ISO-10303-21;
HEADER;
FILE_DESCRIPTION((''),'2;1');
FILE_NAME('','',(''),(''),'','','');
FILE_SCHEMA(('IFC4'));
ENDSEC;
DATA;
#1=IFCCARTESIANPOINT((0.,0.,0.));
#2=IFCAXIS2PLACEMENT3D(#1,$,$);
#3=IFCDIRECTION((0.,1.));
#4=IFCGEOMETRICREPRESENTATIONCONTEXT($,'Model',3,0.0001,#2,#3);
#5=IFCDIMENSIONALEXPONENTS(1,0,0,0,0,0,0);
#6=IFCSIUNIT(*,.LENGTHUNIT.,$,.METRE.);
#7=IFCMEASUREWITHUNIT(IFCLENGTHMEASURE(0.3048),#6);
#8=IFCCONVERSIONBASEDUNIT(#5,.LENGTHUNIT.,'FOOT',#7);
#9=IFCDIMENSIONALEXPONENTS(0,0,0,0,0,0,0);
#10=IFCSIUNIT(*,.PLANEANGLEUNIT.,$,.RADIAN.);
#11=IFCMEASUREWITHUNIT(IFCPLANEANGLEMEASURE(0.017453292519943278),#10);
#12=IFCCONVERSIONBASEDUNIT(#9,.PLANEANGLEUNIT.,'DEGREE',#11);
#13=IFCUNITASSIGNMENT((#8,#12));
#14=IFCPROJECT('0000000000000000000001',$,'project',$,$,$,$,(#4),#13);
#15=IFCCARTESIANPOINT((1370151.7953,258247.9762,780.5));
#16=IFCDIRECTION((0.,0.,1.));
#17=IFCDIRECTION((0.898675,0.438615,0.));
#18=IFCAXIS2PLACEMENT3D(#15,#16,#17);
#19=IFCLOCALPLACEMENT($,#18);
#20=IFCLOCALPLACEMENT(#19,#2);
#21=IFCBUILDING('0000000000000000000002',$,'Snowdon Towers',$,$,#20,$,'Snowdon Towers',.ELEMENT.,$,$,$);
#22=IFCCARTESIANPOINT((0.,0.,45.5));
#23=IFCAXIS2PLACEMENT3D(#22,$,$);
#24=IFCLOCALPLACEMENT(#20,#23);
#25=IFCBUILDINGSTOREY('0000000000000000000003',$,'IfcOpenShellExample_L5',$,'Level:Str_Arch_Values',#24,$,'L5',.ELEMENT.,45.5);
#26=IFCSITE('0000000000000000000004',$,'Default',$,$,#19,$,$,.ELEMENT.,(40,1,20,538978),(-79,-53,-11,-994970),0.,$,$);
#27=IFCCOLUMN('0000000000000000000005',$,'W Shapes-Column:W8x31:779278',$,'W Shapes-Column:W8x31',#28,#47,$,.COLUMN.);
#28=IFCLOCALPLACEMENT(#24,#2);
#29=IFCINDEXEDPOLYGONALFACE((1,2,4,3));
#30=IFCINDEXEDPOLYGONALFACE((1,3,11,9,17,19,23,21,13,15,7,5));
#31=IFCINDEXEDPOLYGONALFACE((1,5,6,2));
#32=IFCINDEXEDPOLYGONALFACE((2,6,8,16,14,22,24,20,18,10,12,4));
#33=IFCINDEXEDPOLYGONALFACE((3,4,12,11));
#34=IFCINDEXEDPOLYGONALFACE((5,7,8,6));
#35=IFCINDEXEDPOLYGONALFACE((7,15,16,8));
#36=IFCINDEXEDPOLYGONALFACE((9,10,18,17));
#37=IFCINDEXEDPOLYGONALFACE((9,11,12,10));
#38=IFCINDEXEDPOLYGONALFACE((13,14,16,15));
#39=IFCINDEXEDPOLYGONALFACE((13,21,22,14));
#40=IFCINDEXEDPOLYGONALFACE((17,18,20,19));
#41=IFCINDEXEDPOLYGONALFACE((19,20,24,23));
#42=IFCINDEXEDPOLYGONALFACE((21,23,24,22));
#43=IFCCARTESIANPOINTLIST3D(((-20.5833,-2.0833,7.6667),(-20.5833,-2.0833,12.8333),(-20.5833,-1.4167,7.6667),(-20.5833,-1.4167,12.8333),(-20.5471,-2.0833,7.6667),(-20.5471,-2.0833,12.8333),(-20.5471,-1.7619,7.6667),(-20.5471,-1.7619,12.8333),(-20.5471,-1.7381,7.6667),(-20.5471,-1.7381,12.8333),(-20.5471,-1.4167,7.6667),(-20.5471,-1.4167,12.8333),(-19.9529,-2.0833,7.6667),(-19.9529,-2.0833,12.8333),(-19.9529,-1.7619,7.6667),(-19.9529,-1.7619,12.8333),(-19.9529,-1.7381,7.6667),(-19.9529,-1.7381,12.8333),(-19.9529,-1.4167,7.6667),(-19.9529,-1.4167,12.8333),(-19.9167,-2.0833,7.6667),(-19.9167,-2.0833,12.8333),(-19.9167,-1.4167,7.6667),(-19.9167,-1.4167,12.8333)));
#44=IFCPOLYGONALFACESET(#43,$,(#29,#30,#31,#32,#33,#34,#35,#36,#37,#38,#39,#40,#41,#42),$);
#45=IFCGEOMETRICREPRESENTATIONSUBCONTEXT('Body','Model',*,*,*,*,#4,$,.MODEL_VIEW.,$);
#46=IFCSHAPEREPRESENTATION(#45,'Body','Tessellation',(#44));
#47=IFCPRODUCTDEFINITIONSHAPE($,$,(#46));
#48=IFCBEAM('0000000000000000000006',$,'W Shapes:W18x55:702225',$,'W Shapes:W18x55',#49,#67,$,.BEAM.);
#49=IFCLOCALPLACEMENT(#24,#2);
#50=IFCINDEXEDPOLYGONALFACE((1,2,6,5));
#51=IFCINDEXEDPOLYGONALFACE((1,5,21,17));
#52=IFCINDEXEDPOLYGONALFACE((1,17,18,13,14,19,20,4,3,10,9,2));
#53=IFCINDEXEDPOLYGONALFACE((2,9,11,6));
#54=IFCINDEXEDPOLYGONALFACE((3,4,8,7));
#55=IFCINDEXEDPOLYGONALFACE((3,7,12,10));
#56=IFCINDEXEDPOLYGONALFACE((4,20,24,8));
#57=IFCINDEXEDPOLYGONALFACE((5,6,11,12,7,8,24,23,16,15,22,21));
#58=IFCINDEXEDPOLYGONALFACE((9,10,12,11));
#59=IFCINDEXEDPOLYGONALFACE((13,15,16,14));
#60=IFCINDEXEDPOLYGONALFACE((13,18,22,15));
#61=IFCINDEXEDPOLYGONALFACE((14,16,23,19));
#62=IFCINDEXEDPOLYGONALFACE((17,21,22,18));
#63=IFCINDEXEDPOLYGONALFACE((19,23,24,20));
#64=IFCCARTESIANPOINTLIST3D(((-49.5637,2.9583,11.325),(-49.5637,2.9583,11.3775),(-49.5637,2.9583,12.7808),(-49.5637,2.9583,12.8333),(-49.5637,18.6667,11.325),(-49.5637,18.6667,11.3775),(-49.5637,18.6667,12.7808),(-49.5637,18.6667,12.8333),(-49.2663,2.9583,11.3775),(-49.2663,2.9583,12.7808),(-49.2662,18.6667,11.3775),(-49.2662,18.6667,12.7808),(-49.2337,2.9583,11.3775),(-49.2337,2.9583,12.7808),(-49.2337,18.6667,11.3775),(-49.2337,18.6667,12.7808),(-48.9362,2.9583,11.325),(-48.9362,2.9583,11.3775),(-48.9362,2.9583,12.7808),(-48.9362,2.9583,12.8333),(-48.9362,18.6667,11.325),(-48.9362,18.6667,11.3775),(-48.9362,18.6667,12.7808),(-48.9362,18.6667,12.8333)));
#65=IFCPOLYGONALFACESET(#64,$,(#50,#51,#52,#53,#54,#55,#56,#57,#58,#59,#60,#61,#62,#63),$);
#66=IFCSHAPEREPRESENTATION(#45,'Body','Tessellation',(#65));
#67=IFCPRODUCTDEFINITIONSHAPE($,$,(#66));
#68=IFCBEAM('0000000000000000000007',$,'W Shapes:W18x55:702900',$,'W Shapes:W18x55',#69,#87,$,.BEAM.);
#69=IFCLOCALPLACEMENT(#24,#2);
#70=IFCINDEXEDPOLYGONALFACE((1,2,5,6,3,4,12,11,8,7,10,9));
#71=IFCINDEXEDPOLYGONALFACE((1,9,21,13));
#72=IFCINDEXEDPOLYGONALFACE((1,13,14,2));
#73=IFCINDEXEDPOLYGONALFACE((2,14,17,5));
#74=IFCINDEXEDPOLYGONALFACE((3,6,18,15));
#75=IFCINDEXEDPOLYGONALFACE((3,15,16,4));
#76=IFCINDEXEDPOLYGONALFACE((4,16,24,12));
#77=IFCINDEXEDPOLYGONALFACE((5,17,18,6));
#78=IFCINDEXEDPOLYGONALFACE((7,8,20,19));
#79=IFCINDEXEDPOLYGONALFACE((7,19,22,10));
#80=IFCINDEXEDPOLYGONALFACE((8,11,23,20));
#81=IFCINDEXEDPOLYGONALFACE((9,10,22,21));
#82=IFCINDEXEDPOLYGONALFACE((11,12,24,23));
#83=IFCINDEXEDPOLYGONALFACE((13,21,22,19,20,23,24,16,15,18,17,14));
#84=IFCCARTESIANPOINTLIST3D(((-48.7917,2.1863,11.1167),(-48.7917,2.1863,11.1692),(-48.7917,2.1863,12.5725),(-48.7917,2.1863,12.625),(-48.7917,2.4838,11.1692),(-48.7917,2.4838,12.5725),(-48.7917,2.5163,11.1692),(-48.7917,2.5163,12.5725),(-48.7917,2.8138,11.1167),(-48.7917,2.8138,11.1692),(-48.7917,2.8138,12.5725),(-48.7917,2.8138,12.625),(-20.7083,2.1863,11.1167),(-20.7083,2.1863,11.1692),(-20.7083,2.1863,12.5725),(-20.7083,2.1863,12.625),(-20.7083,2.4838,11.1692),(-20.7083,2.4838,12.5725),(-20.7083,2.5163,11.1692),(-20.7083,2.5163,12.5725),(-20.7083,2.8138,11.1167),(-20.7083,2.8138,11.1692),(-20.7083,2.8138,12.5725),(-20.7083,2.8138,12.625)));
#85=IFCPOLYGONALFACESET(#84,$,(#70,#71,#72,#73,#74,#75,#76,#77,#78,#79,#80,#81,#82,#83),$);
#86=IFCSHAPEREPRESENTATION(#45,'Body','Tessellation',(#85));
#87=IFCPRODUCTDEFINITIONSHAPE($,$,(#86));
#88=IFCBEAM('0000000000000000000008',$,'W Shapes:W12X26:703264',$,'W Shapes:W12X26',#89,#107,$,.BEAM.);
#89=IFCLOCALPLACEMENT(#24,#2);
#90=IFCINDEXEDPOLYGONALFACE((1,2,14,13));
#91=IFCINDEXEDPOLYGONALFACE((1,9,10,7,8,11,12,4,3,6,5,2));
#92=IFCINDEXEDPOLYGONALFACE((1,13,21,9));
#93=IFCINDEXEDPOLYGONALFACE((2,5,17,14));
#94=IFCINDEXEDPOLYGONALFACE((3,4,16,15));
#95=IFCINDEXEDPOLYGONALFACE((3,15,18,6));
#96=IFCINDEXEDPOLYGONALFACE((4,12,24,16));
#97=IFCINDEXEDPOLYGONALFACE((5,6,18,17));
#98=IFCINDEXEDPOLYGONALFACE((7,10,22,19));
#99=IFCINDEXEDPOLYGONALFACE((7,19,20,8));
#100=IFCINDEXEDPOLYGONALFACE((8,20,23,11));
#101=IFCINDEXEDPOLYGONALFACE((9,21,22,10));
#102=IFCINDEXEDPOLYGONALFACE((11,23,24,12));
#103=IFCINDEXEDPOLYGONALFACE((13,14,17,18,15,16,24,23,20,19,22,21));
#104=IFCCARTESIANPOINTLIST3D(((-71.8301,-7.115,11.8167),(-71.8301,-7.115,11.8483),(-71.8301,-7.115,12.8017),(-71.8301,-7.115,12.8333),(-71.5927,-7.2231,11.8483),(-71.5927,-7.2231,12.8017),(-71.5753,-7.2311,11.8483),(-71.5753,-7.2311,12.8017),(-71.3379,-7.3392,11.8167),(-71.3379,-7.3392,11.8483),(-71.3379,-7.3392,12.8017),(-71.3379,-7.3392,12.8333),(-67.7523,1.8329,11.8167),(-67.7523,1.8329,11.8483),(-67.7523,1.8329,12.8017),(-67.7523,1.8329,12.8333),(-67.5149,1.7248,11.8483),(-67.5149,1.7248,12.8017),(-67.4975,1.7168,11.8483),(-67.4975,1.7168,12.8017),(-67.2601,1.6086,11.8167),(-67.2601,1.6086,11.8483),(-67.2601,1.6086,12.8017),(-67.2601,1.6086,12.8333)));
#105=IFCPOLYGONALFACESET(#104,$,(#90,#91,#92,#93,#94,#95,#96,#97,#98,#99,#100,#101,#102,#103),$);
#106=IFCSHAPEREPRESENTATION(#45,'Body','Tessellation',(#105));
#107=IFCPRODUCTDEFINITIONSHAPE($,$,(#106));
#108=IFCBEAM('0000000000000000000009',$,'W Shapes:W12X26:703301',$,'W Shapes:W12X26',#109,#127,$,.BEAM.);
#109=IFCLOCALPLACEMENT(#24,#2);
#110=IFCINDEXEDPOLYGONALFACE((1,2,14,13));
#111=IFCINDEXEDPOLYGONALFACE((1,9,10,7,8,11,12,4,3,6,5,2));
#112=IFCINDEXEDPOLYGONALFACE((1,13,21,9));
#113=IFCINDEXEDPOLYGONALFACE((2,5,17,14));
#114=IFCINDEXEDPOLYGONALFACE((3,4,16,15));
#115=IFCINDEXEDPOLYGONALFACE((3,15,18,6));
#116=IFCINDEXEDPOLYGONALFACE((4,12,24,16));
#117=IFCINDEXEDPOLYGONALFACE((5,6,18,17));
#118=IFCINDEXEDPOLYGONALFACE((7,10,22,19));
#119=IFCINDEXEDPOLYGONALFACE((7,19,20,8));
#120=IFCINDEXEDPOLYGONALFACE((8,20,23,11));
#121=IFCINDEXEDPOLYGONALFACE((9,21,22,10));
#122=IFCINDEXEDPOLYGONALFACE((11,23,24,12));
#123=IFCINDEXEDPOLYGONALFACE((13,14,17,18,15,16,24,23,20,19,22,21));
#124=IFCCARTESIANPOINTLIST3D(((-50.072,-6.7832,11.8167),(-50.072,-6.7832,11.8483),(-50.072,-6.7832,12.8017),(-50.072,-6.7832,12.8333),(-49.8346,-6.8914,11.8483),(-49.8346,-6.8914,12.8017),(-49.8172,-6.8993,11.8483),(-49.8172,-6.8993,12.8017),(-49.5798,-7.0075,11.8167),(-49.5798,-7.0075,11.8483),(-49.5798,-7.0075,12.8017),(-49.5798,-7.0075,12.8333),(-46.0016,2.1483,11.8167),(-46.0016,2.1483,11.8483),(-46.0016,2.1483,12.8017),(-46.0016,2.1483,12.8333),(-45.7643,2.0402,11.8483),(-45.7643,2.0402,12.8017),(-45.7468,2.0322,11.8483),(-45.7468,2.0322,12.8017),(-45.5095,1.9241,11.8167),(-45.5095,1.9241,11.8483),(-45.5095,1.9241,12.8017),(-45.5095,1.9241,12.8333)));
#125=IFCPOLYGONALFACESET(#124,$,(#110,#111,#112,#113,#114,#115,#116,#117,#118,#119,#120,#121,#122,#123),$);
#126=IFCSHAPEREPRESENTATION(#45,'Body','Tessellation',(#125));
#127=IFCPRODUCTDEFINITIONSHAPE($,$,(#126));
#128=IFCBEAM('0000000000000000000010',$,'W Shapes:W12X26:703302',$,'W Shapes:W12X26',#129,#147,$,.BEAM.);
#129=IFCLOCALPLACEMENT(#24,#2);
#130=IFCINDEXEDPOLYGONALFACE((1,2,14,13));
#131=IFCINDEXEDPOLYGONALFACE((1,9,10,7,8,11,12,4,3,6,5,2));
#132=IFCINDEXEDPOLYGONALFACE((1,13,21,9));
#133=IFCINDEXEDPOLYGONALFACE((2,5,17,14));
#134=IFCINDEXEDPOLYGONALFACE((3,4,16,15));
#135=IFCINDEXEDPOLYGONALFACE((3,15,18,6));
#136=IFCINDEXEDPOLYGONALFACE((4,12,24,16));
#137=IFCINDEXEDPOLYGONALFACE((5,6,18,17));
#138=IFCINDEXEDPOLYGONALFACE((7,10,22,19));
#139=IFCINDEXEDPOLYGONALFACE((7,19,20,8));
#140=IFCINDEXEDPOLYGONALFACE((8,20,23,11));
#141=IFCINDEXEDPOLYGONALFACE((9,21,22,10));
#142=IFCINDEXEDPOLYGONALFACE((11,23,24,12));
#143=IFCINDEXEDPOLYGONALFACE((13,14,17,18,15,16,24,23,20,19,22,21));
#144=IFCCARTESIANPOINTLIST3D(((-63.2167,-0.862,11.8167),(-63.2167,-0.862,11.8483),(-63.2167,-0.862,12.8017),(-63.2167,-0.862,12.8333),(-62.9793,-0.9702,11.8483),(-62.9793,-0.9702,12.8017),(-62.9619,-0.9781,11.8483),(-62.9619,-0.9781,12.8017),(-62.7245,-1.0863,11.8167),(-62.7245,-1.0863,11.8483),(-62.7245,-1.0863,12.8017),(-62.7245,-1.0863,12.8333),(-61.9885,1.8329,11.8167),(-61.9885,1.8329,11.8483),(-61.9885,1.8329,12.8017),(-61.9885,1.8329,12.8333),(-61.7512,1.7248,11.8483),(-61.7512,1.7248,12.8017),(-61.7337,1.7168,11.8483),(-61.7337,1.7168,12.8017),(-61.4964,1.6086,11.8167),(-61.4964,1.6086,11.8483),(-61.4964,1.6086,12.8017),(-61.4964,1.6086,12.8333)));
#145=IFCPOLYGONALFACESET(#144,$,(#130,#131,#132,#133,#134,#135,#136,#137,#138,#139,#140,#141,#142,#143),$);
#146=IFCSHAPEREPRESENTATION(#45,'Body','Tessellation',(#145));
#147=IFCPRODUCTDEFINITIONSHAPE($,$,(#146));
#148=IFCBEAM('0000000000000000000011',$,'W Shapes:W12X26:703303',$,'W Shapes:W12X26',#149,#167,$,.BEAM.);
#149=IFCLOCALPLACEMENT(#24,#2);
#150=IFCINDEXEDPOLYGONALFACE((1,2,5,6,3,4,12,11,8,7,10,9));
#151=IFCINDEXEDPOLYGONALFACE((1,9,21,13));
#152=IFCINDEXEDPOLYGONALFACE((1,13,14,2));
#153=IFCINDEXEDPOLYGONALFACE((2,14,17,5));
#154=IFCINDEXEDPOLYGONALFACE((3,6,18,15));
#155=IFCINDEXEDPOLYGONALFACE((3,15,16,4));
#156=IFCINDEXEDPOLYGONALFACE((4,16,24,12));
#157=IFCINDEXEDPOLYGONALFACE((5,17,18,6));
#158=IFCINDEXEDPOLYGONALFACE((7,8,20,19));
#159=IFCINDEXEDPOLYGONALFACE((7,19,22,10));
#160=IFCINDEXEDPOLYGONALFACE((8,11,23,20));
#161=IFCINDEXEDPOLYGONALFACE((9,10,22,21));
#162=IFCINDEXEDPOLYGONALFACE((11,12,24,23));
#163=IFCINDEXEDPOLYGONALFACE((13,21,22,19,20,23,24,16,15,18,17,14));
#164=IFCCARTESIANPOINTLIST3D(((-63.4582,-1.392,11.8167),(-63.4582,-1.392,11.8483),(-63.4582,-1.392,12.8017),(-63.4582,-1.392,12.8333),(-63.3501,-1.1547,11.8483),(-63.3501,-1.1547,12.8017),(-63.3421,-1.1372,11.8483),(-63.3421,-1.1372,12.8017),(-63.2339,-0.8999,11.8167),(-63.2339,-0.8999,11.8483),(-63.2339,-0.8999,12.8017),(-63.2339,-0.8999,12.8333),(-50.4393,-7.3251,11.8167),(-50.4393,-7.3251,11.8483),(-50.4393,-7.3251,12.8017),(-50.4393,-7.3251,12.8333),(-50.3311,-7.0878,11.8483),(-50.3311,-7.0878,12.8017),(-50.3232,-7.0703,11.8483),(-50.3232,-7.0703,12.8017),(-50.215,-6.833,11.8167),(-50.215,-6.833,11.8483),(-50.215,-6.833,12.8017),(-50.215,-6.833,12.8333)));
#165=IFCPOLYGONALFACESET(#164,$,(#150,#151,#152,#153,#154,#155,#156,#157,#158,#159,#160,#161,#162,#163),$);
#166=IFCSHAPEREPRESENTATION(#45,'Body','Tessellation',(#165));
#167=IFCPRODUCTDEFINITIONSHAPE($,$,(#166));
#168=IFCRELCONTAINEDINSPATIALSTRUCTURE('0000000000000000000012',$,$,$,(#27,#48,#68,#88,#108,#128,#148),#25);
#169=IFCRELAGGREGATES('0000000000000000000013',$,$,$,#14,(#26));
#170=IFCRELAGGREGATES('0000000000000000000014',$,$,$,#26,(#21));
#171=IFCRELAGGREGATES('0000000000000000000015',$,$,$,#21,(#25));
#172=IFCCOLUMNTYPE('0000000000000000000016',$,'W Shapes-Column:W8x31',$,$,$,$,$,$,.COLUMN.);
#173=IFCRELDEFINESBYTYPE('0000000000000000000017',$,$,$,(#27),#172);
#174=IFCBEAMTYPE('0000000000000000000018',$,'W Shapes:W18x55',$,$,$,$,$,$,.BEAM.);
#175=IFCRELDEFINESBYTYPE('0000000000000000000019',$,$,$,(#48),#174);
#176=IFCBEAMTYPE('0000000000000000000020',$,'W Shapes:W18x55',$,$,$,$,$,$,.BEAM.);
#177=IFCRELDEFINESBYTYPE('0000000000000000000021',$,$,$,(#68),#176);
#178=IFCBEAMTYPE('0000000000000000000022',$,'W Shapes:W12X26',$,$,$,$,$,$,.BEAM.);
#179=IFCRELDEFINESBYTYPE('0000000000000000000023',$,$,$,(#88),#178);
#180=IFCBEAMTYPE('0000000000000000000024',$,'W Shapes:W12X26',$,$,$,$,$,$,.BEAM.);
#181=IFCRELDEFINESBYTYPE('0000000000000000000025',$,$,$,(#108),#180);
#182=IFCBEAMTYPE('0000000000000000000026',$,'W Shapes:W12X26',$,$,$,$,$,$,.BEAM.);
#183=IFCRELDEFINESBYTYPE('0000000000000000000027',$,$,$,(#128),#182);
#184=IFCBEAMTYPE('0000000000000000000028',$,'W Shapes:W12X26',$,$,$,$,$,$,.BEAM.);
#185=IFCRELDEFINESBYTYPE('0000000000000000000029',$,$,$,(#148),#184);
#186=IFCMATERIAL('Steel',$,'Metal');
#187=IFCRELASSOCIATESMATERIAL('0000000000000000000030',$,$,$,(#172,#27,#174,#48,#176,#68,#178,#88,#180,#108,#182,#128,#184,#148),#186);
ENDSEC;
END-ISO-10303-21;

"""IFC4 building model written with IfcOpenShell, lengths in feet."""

from ifc_helpers import new_model, entity, si_unit, converted_unit, direction, frame, origin, place, context, subcontext, project, spatial, indexed_curve, outline, extrude, source, transform, mapped, material, type_object, type_shapes, element, save


model = new_model("IFC4")

# Units and contexts
model_context = context("Model", 3, precision=0.0001, world=origin(), true_north=direction((0.0, 1.0)))
body_context = subcontext(model_context, "Body", "Model", "MODEL_VIEW")
ifc_project = project(units=[converted_unit("LENGTHUNIT", "FOOT", entity("IfcLengthMeasure", 0.3048), si_unit("LENGTHUNIT", "METRE"), dimensions=[1, 0, 0, 0, 0, 0, 0]), converted_unit("PLANEANGLEUNIT", "DEGREE", entity("IfcPlaneAngleMeasure", 0.017453292519943278), si_unit("PLANEANGLEUNIT", "RADIAN"), dimensions=[0, 0, 0, 0, 0, 0, 0])], contexts=[model_context])

# Site, building, storey
site_placement = place(None, frame((1370151.7953, 258247.9762, 780.5), z_axis=(0.0, 0.0, 1.0), x_axis=(0.898675, 0.438615, 0.0)))
site = spatial("IfcSite", under=ifc_project, at=site_placement, Name="Default", CompositionType="ELEMENT", RefLatitude=(40, 1, 20, 538978), RefLongitude=(-79, -53, -11, -994970), RefElevation=0.0)
building_placement = place(site_placement, origin())
building = spatial("IfcBuilding", under=site, at=building_placement, Name="Snowdon Towers", LongName="Snowdon Towers", CompositionType="ELEMENT")
storey_placement = place(building_placement, frame((0.0, 0.0, 45.5)))
storey = spatial("IfcBuildingStorey", under=building, at=storey_placement, Name="IfcOpenShellExample_L5", ObjectType="Level:Str_Arch_Values", LongName="L5", CompositionType="ELEMENT", Elevation=45.5)

# Column
ifc_material = material(Name="Steel", Category="Metal")
column_type = type_object("IfcColumnType", Name="W Shapes-Column:W8x31", PredefinedType="COLUMN", material=ifc_material)
shared_shape_1 = source(origin(), body_context, "Body", "SweptSolid", [
    extrude(outline(indexed_curve([(-0.3333, -0.3333), (-0.2971, -0.3333), (-0.2971, -0.0119), (0.2971, -0.0119), (0.2971, -0.3333), (0.3333, -0.3333), (0.3333, 0.3333), (0.2971, 0.3333), (0.2971, 0.0119), (-0.2971, 0.0119), (-0.2971, 0.3333), (-0.3333, 0.3333), (-0.3333, -0.3333)], self_intersect=False)), frame((0.0, 0.0, 53.1667), z_axis=(0.0, 0.0, 1.0), x_axis=(0.0, 1.0, 0.0)), (0.0, 0.0, 1.0), 5.1667),
])
type_shapes(column_type, [shared_shape_1])
column_placement = place(storey_placement, frame((-20.25, -1.75, -45.5), z_axis=(0.0, 0.0, 1.0), x_axis=(0.0, 1.0, 0.0)))
element("IfcColumn", 1, at=column_placement, inside=storey, type_object=column_type, material=ifc_material, Name="W Shapes-Column:W8x31:779278", ObjectType="W Shapes-Column:W8x31", PredefinedType="COLUMN", context=body_context, shape_type="MappedRepresentation", body=[
    mapped(shared_shape_1, transform((0.0, 0.0, 0.0), scale=1.0)),
])

# Beams
beam_type_1 = type_object("IfcBeamType", Name="W Shapes:W18x55", PredefinedType="BEAM", material=ifc_material)
shared_shape_2 = source(origin(), body_context, "Body", "SweptSolid", [
    extrude(outline(indexed_curve([(-0.3138, -0.7017), (-0.3138, -0.7542), (0.3138, -0.7542), (0.3138, -0.7017), (0.0162, -0.7017), (0.0162, 0.7017), (0.3138, 0.7017), (0.3138, 0.7542), (-0.3137, 0.7542), (-0.3137, 0.7017), (-0.0163, 0.7017), (-0.0163, -0.7017), (-0.3138, -0.7017)], self_intersect=False)), frame((-7.8125, 0.0, 0.0), z_axis=(-1.0, 0.0, 0.0), x_axis=(0.0, -1.0, 0.0)), (0.0, 0.0, -1.0), 15.7083),
])
type_shapes(beam_type_1, [shared_shape_2])
beam_1_placement = place(storey_placement, frame((-49.25, 10.8542, 12.0792), z_axis=(0.0, 0.0, 1.0), x_axis=(0.0, -1.0, 0.0)))
element("IfcBeam", 2, at=beam_1_placement, inside=storey, type_object=beam_type_1, material=ifc_material, Name="W Shapes:W18x55:702225", ObjectType="W Shapes:W18x55", PredefinedType="BEAM", context=body_context, shape_type="MappedRepresentation", body=[
    mapped(shared_shape_2, transform((0.0, 0.0, 0.0), scale=1.0)),
])
beam_type_2 = type_object("IfcBeamType", Name="W Shapes:W18x55", PredefinedType="BEAM", material=ifc_material)
shared_shape_3 = source(origin(), body_context, "Body", "SweptSolid", [
    extrude(outline(indexed_curve([(-0.3138, -0.7017), (-0.3138, -0.7542), (0.3138, -0.7542), (0.3138, -0.7017), (0.0162, -0.7017), (0.0162, 0.7017), (0.3138, 0.7017), (0.3138, 0.7542), (-0.3137, 0.7542), (-0.3137, 0.7017), (-0.0163, 0.7017), (-0.0163, -0.7017), (-0.3138, -0.7017)], self_intersect=False)), frame((-14.0417, 0.0, 0.0), z_axis=(-1.0, 0.0, 0.0), x_axis=(0.0, -1.0, 0.0)), (0.0, 0.0, -1.0), 28.0833),
])
type_shapes(beam_type_2, [shared_shape_3])
beam_2_placement = place(storey_placement, frame((-34.75, 2.5, 11.8708)))
element("IfcBeam", 3, at=beam_2_placement, inside=storey, type_object=beam_type_2, material=ifc_material, Name="W Shapes:W18x55:702900", ObjectType="W Shapes:W18x55", PredefinedType="BEAM", context=body_context, shape_type="MappedRepresentation", body=[
    mapped(shared_shape_3, transform((0.0, 0.0, 0.0), scale=1.0)),
])
beam_type_3 = type_object("IfcBeamType", Name="W Shapes:W12X26", PredefinedType="BEAM", material=ifc_material)
shared_shape_4 = source(origin(), body_context, "Body", "SweptSolid", [
    extrude(outline(indexed_curve([(-0.2704, -0.4767), (-0.2704, -0.5083), (0.2704, -0.5083), (0.2704, -0.4767), (0.0096, -0.4767), (0.0096, 0.4767), (0.2704, 0.4767), (0.2704, 0.5083), (-0.2704, 0.5083), (-0.2704, 0.4767), (-0.0096, 0.4767), (-0.0096, -0.4767), (-0.2704, -0.4767)], self_intersect=False)), frame((-5.1887, 0.0, 0.0), z_axis=(-1.0, 0.0, 0.0), x_axis=(0.0, -1.0, 0.0)), (0.0, 0.0, -1.0), 9.8332),
])
type_shapes(beam_type_3, [shared_shape_4])
beam_3_placement = place(storey_placement, frame((-69.4323, -2.5055, 12.325), z_axis=(0.0, 0.0, 1.0), x_axis=(0.414693, 0.909961, 0.0)))
element("IfcBeam", 4, at=beam_3_placement, inside=storey, type_object=beam_type_3, material=ifc_material, Name="W Shapes:W12X26:703264", ObjectType="W Shapes:W12X26", PredefinedType="BEAM", context=body_context, shape_type="MappedRepresentation", body=[
    mapped(shared_shape_4, transform((0.0, 0.0, 0.0), scale=1.0)),
])
beam_type_4 = type_object("IfcBeamType", Name="W Shapes:W12X26", PredefinedType="BEAM", material=ifc_material)
shared_shape_5 = source(origin(), body_context, "Body", "SweptSolid", [
    extrude(outline(indexed_curve([(-0.2704, -0.4767), (-0.2704, -0.5083), (0.2704, -0.5083), (0.2704, -0.4767), (0.0096, -0.4767), (0.0096, 0.4767), (0.2704, 0.4767), (0.2704, 0.5083), (-0.2704, 0.5083), (-0.2704, 0.4767), (-0.0096, 0.4767), (-0.0096, -0.4767), (-0.2704, -0.4767)], self_intersect=False)), frame((-4.9762, 0.0, 0.0), z_axis=(-1.0, 0.0, 0.0), x_axis=(0.0, -1.0, 0.0)), (0.0, 0.0, -1.0), 9.8153),
])
type_shapes(beam_type_4, [shared_shape_5])
beam_4_placement = place(storey_placement, frame((-47.7623, -2.3673, 12.325), z_axis=(0.0, 0.0, 1.0), x_axis=(0.414693, 0.909961, 0.0)))
element("IfcBeam", 5, at=beam_4_placement, inside=storey, type_object=beam_type_4, material=ifc_material, Name="W Shapes:W12X26:703301", ObjectType="W Shapes:W12X26", PredefinedType="BEAM", context=body_context, shape_type="MappedRepresentation", body=[
    mapped(shared_shape_5, transform((0.0, 0.0, 0.0), scale=1.0)),
])
beam_type_5 = type_object("IfcBeamType", Name="W Shapes:W12X26", PredefinedType="BEAM", material=ifc_material)
shared_shape_6 = source(origin(), body_context, "Body", "SweptSolid", [
    extrude(outline(indexed_curve([(-0.2704, -0.4767), (-0.2704, -0.5083), (0.2704, -0.5083), (0.2704, -0.4767), (0.0096, -0.4767), (0.0096, 0.4767), (0.2704, 0.4767), (0.2704, 0.5083), (-0.2704, 0.5083), (-0.2704, 0.4767), (-0.0096, 0.4767), (-0.0096, -0.4767), (-0.2704, -0.4767)], self_intersect=False)), frame((-1.7529, 0.0, 0.0), z_axis=(-1.0, 0.0, 0.0), x_axis=(0.0, -1.0, 0.0)), (0.0, 0.0, -1.0), 2.9616),
])
type_shapes(beam_type_5, [shared_shape_6])
beam_5_placement = place(storey_placement, frame((-62.2437, 0.6209, 12.325), z_axis=(0.0, 0.0, 1.0), x_axis=(0.414693, 0.909961, 0.0)))
element("IfcBeam", 6, at=beam_5_placement, inside=storey, type_object=beam_type_5, material=ifc_material, Name="W Shapes:W12X26:703302", ObjectType="W Shapes:W12X26", PredefinedType="BEAM", context=body_context, shape_type="MappedRepresentation", body=[
    mapped(shared_shape_6, transform((0.0, 0.0, 0.0), scale=1.0)),
])
beam_type_6 = type_object("IfcBeamType", Name="W Shapes:W12X26", PredefinedType="BEAM", material=ifc_material)
shared_shape_7 = source(origin(), body_context, "Body", "SweptSolid", [
    extrude(outline(indexed_curve([(-0.2704, -0.4767), (-0.2704, -0.5083), (0.2704, -0.5083), (0.2704, -0.4767), (0.0096, -0.4767), (0.0096, 0.4767), (0.2704, 0.4767), (0.2704, 0.5083), (-0.2704, 0.5083), (-0.2704, 0.4767), (-0.0096, 0.4767), (-0.0096, -0.4767), (-0.2704, -0.4767)], self_intersect=False)), frame((-7.4813, 0.0, 0.0), z_axis=(-1.0, 0.0, 0.0), x_axis=(0.0, -1.0, 0.0)), (0.0, 0.0, -1.0), 14.3071),
])
type_shapes(beam_type_6, [shared_shape_7])
beam_6_placement = place(storey_placement, frame((-56.5384, -4.2484, 12.325), z_axis=(0.0, 0.0, 1.0), x_axis=(0.909961, -0.414693, 0.0)))
element("IfcBeam", 7, at=beam_6_placement, inside=storey, type_object=beam_type_6, material=ifc_material, Name="W Shapes:W12X26:703303", ObjectType="W Shapes:W12X26", PredefinedType="BEAM", context=body_context, shape_type="MappedRepresentation", body=[
    mapped(shared_shape_7, transform((0.0, 0.0, 0.0), scale=1.0)),
])

save(model, "model.ifc")
